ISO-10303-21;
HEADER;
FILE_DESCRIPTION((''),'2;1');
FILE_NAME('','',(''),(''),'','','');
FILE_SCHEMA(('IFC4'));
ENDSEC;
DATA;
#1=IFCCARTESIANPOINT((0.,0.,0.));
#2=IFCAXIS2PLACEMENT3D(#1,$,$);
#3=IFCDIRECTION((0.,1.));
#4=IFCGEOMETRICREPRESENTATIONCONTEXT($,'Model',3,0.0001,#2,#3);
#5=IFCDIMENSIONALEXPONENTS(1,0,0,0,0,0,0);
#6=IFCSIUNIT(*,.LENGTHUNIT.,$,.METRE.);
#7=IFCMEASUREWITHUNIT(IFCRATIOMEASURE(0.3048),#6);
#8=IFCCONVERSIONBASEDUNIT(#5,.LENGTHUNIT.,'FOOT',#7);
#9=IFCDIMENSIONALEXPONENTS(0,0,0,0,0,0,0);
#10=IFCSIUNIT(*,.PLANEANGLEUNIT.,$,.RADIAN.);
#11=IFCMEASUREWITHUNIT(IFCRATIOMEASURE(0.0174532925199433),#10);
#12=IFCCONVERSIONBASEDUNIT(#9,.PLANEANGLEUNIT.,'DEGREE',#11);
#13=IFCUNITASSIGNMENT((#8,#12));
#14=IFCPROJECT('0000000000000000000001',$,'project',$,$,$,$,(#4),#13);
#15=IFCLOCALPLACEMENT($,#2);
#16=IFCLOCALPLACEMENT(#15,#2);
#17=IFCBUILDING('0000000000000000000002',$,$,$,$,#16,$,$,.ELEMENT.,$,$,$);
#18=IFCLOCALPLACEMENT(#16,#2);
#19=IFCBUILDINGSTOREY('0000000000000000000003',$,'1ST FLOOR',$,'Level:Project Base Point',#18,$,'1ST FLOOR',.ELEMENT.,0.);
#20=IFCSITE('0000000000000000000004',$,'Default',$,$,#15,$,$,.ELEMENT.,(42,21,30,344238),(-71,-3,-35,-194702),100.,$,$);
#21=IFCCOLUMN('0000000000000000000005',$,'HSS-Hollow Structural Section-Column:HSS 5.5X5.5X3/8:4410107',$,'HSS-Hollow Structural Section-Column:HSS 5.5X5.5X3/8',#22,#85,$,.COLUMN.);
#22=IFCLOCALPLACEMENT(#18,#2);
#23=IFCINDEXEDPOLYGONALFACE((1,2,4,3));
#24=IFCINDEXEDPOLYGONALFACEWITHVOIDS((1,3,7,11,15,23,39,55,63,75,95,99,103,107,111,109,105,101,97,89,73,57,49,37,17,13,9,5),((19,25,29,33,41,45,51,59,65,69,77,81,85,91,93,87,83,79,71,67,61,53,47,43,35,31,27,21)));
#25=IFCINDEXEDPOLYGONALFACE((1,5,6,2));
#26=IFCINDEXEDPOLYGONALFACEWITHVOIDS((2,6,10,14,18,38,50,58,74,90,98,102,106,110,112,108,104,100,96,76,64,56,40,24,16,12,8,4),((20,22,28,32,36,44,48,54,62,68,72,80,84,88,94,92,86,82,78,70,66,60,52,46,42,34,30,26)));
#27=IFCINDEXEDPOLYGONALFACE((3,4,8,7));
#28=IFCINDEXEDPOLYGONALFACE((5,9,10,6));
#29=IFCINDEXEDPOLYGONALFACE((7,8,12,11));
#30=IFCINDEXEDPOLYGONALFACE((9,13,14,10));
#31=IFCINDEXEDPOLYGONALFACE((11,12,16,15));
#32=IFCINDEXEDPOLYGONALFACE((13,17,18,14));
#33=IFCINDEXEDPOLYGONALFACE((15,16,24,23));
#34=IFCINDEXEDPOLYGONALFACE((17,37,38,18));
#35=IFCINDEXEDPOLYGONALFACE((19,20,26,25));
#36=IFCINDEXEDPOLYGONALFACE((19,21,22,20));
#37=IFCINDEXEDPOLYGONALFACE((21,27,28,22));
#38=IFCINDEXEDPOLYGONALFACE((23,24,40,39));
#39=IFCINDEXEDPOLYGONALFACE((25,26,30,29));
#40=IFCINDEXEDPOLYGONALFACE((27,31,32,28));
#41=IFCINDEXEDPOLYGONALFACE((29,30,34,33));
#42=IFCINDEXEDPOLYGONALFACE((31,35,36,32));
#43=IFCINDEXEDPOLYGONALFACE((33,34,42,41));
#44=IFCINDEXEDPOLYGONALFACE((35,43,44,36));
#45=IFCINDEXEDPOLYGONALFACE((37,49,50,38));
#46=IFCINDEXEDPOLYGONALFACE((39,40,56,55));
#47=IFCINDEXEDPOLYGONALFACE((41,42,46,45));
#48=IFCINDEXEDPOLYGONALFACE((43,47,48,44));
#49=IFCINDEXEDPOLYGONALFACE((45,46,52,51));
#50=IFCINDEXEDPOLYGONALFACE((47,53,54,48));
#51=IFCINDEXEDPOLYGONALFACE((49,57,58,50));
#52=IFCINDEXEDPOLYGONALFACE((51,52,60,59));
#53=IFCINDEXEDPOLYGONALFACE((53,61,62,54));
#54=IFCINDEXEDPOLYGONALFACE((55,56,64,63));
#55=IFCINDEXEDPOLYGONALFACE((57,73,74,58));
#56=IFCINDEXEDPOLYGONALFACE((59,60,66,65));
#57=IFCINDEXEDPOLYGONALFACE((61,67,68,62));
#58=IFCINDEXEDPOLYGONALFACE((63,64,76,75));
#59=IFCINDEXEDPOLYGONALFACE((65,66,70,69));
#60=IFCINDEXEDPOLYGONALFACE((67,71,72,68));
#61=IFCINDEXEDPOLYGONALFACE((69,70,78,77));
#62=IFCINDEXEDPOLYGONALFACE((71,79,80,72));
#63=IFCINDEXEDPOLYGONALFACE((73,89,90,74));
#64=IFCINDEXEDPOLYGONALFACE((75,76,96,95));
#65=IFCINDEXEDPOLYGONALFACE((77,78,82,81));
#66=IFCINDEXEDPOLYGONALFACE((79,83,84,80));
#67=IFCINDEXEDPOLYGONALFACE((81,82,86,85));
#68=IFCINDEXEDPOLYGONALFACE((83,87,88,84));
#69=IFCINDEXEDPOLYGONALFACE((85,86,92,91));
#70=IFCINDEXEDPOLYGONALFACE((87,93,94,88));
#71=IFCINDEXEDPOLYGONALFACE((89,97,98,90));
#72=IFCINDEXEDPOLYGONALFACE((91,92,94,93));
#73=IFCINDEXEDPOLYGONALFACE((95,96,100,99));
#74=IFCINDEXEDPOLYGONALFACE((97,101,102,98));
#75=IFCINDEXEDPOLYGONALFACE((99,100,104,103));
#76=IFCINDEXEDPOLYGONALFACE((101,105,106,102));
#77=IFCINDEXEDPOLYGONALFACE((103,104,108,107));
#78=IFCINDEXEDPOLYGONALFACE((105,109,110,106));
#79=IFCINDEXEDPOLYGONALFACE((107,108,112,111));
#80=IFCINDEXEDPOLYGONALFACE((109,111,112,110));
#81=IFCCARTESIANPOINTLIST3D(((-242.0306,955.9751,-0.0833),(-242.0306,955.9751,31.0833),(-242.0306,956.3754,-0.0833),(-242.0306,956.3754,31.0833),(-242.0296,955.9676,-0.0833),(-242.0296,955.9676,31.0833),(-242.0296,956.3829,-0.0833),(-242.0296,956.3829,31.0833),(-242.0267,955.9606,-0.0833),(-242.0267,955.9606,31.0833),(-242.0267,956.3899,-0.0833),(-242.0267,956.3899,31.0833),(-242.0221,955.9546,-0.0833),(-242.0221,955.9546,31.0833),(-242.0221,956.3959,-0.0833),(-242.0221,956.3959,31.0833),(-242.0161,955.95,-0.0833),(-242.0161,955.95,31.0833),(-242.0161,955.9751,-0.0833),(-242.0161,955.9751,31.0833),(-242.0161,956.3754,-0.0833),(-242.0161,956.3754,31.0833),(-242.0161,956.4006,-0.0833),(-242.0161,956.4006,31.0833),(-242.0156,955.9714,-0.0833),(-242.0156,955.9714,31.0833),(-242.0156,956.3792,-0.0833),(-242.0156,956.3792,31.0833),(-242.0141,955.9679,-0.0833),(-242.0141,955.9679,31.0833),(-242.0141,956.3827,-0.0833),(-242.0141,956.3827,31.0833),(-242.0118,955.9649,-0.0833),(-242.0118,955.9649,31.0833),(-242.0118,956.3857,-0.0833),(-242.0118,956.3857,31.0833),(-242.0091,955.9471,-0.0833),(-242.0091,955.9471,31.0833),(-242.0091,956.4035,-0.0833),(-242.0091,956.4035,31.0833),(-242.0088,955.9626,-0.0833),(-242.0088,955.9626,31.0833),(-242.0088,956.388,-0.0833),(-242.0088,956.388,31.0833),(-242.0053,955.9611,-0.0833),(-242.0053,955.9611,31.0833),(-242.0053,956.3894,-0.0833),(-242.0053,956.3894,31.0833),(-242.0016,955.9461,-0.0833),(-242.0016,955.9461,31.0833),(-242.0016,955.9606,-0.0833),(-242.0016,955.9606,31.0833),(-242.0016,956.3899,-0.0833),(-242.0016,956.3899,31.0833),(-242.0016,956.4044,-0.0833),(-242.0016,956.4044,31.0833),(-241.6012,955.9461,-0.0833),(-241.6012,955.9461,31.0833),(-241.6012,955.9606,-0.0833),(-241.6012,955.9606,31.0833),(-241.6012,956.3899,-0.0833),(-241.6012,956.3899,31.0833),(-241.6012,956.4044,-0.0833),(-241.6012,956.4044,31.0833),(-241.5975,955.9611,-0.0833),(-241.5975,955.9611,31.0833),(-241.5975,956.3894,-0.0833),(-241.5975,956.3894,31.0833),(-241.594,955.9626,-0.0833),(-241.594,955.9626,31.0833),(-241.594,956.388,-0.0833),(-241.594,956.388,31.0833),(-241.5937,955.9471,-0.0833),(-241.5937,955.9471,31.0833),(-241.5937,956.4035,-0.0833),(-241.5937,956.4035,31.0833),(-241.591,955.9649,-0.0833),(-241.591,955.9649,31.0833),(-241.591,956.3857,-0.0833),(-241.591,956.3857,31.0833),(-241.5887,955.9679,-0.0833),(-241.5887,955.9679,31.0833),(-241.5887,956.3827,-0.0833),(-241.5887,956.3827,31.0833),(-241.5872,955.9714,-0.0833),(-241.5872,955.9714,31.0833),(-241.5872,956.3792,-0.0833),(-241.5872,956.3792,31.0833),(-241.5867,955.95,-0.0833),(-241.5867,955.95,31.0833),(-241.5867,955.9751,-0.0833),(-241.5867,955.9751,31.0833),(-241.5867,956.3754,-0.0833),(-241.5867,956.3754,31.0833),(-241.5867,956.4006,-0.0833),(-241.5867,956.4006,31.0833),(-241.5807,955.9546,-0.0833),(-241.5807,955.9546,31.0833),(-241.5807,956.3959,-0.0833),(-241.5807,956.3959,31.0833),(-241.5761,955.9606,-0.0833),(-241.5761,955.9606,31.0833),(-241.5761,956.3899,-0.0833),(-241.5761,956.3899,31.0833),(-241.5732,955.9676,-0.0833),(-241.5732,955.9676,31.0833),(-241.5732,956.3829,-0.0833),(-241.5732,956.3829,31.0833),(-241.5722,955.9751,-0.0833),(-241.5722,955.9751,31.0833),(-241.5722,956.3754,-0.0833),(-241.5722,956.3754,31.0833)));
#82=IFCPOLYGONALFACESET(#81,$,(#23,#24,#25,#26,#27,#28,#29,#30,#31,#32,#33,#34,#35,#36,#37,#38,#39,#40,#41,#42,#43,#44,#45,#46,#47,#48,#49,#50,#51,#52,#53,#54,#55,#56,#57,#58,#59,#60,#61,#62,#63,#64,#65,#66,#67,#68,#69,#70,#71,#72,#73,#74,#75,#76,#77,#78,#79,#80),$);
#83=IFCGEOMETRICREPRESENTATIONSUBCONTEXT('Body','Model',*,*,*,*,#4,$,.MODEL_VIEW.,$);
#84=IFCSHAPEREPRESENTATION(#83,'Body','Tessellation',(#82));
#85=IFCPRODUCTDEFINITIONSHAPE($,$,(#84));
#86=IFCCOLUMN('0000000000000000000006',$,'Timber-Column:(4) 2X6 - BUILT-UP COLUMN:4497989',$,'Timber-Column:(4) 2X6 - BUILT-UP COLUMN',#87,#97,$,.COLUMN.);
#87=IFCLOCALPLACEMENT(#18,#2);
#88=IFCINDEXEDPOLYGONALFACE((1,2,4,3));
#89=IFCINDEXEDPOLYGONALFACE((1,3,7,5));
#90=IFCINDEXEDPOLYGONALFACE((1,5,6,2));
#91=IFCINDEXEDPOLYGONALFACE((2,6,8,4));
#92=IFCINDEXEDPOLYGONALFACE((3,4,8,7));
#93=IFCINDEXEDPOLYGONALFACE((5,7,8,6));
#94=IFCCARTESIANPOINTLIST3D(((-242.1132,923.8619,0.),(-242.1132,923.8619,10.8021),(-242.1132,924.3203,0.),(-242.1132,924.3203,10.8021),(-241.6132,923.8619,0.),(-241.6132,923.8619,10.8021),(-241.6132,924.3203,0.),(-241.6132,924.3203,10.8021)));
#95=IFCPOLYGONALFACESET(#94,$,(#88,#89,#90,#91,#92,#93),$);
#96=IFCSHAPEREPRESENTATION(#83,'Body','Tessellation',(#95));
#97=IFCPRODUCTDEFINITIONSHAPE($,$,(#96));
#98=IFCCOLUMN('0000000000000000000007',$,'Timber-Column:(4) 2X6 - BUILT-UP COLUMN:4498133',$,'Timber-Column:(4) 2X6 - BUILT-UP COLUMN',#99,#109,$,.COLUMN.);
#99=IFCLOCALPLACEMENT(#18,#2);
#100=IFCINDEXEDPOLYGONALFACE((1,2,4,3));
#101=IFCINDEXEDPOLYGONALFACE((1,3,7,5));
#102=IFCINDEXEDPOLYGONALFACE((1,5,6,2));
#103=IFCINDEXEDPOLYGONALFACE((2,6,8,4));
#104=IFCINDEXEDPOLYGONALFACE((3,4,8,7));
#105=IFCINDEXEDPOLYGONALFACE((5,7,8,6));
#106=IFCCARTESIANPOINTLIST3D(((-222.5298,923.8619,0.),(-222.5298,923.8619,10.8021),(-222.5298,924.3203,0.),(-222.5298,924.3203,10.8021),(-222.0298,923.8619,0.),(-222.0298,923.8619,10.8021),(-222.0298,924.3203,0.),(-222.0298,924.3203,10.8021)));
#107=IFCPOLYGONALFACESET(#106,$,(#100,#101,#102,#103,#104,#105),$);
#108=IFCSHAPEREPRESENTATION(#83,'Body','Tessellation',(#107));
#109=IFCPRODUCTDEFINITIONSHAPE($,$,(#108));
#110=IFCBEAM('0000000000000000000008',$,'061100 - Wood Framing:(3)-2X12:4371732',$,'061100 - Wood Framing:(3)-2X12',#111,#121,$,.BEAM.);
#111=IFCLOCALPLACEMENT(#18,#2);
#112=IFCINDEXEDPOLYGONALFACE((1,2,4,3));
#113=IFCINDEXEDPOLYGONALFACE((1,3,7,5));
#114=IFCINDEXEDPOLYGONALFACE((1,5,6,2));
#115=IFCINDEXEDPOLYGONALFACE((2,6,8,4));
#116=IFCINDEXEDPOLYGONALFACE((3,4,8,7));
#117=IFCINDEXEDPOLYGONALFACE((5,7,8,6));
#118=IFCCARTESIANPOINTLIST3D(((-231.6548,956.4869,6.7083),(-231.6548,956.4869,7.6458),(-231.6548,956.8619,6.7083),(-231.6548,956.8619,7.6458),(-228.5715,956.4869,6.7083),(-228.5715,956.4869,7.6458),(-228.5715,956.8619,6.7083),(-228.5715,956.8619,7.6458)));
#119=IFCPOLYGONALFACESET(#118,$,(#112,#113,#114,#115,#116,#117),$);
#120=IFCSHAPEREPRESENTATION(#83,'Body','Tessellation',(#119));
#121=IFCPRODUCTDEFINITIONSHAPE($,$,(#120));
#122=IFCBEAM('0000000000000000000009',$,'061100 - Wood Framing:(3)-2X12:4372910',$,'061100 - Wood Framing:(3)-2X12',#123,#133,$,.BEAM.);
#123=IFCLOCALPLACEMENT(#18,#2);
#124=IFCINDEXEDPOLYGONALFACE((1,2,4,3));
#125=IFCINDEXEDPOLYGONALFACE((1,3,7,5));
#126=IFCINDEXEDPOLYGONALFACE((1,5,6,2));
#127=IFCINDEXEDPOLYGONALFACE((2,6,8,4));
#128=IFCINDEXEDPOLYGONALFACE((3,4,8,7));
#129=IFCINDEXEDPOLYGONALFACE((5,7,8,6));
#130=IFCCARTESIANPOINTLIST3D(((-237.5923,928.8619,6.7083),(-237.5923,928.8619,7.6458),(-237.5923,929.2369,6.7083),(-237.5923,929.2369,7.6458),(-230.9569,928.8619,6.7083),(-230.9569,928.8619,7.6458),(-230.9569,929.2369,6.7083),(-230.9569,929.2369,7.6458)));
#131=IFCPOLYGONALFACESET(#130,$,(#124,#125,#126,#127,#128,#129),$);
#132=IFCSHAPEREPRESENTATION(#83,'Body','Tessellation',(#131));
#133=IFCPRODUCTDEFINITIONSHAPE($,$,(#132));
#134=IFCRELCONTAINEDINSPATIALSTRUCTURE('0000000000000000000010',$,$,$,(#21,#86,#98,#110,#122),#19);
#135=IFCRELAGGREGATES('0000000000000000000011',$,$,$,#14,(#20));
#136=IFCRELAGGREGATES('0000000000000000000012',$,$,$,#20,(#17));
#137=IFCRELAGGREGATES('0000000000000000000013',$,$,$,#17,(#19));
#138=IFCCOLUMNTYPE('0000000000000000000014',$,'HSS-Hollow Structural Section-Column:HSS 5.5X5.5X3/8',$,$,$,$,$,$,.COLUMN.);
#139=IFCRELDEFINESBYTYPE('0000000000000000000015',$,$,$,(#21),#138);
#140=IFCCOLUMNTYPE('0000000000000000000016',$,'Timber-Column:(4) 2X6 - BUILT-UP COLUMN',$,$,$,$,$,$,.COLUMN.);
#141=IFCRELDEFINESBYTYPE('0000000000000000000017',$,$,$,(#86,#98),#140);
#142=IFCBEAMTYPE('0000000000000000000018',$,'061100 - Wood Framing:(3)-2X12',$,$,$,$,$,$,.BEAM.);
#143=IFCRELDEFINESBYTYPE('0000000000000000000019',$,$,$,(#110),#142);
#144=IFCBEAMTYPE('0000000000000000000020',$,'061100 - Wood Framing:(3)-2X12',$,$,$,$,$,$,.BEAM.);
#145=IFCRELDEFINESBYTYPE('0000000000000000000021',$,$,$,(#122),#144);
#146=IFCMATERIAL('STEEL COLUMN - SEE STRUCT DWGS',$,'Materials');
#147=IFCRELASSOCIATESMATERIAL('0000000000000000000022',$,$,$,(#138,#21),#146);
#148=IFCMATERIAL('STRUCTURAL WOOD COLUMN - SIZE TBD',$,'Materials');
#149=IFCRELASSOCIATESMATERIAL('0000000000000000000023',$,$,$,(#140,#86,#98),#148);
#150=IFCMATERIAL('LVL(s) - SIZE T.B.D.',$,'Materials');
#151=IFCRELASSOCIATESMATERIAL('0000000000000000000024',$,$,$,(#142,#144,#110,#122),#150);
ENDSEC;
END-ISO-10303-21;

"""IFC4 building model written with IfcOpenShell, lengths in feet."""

from ifc_helpers import new_model, entity, si_unit, converted_unit, direction, frame, frame_2d, origin, origin_2d_with_axis, place, context, subcontext, project, spatial, polyline, circle_curve, parameter, trimmed, segment, composite_curve, rectangle, outline, extrude, source, transform, mapped, material, material_profile, profile_set, profile_usage, type_object, type_shapes, element, save


model = new_model("IFC4")

# Units and contexts
model_context = context("Model", 3, precision=0.0001, world=origin(), true_north=direction((0.0, 1.0)))
body_context = subcontext(model_context, "Body", "Model", "MODEL_VIEW")
ifc_project = project(units=[converted_unit("LENGTHUNIT", "FOOT", entity("IfcRatioMeasure", 0.3048), si_unit("LENGTHUNIT", "METRE"), dimensions=[1, 0, 0, 0, 0, 0, 0]), converted_unit("PLANEANGLEUNIT", "DEGREE", entity("IfcRatioMeasure", 0.0174532925199433), si_unit("PLANEANGLEUNIT", "RADIAN"), dimensions=[0, 0, 0, 0, 0, 0, 0])], contexts=[model_context])

# Site, building, storey
site_placement = place(None, origin())
site = spatial("IfcSite", under=ifc_project, at=site_placement, Name="Default", CompositionType="ELEMENT", RefLatitude=(42, 21, 30, 344238), RefLongitude=(-71, -3, -35, -194702), RefElevation=100.0)
building_placement = place(site_placement, origin())
building = spatial("IfcBuilding", under=site, at=building_placement, CompositionType="ELEMENT")
storey_placement = place(building_placement, origin())
storey = spatial("IfcBuildingStorey", under=building, at=storey_placement, Name="1ST FLOOR", ObjectType="Level:Project Base Point", LongName="1ST FLOOR", CompositionType="ELEMENT", Elevation=0.0)

# Columns
ifc_material_1 = material(Name="STEEL COLUMN - SEE STRUCT DWGS", Category="Materials")
ifc_material_profile_1 = material_profile(ifc_material_1, outline(composite_curve([segment(trimmed(circle_curve(frame_2d((0.2002, -0.2002), x_axis=(1.0, 0.0)), 0.029), [parameter(270.0)], [parameter(0.0)], True, "PARAMETER"), True, "CONTINUOUS"), segment(polyline([(0.2292, -0.2002), (0.2292, 0.2002)]), True, "CONTINUOUS"), segment(trimmed(circle_curve(frame_2d((0.2002, 0.2002), x_axis=(1.0, 0.0)), 0.029), [parameter(0.0)], [parameter(90.0)], True, "PARAMETER"), True, "CONTINUOUS"), segment(polyline([(0.2002, 0.2292), (-0.2002, 0.2292)]), True, "CONTINUOUS"), segment(trimmed(circle_curve(frame_2d((-0.2002, 0.2002), x_axis=(1.0, 0.0)), 0.029), [parameter(90.0)], [parameter(180.0)], True, "PARAMETER"), True, "CONTINUOUS"), segment(polyline([(-0.2292, 0.2002), (-0.2292, -0.2002)]), True, "CONTINUOUS"), segment(trimmed(circle_curve(frame_2d((-0.2002, -0.2002), x_axis=(1.0, 0.0)), 0.029), [parameter(180.0)], [parameter(270.0)], True, "PARAMETER"), True, "CONTINUOUS"), segment(polyline([(-0.2002, -0.2292), (0.2002, -0.2292)]), True, "CONTINUOUS")], self_intersect=False), holes=[composite_curve([segment(polyline([(0.2002, -0.2147), (-0.2002, -0.2147)]), True, "CONTINUOUS"), segment(trimmed(circle_curve(frame_2d((-0.2002, -0.2002), x_axis=(1.0, 0.0)), 0.0145), [parameter(180.0)], [parameter(270.0)], True, "PARAMETER"), False, "CONTINUOUS"), segment(polyline([(-0.2147, -0.2002), (-0.2147, 0.2002)]), True, "CONTINUOUS"), segment(trimmed(circle_curve(frame_2d((-0.2002, 0.2002), x_axis=(1.0, 0.0)), 0.0145), [parameter(90.0)], [parameter(180.0)], True, "PARAMETER"), False, "CONTINUOUS"), segment(polyline([(-0.2002, 0.2147), (0.2002, 0.2147)]), True, "CONTINUOUS"), segment(trimmed(circle_curve(frame_2d((0.2002, 0.2002), x_axis=(1.0, 0.0)), 0.0145), [parameter(0.0)], [parameter(90.0)], True, "PARAMETER"), False, "CONTINUOUS"), segment(polyline([(0.2147, 0.2002), (0.2147, -0.2002)]), True, "CONTINUOUS"), segment(trimmed(circle_curve(frame_2d((0.2002, -0.2002), x_axis=(1.0, 0.0)), 0.0145), [parameter(270.0)], [parameter(0.0)], True, "PARAMETER"), False, "CONTINUOUS")], self_intersect=False)]), Name="HSS 5.5X5.5X3/8")
ifc_profile_set_1 = profile_set([ifc_material_profile_1], Name="HSS 5.5X5.5X3/8")
ifc_profile_usage_1 = profile_usage(ifc_profile_set_1)
column_type_1 = type_object("IfcColumnType", Name="HSS-Hollow Structural Section-Column:HSS 5.5X5.5X3/8", PredefinedType="COLUMN", material=ifc_profile_set_1)
shared_shape_1 = source(origin(), body_context, "Body", "SweptSolid", [
    extrude(outline(composite_curve([segment(trimmed(circle_curve(frame_2d((0.2002, -0.2002), x_axis=(1.0, 0.0)), 0.029), [parameter(270.0)], [parameter(0.0)], True, "PARAMETER"), True, "CONTINUOUS"), segment(polyline([(0.2292, -0.2002), (0.2292, 0.2002)]), True, "CONTINUOUS"), segment(trimmed(circle_curve(frame_2d((0.2002, 0.2002), x_axis=(1.0, 0.0)), 0.029), [parameter(0.0)], [parameter(90.0)], True, "PARAMETER"), True, "CONTINUOUS"), segment(polyline([(0.2002, 0.2292), (-0.2002, 0.2292)]), True, "CONTINUOUS"), segment(trimmed(circle_curve(frame_2d((-0.2002, 0.2002), x_axis=(1.0, 0.0)), 0.029), [parameter(90.0)], [parameter(180.0)], True, "PARAMETER"), True, "CONTINUOUS"), segment(polyline([(-0.2292, 0.2002), (-0.2292, -0.2002)]), True, "CONTINUOUS"), segment(trimmed(circle_curve(frame_2d((-0.2002, -0.2002), x_axis=(1.0, 0.0)), 0.029), [parameter(180.0)], [parameter(270.0)], True, "PARAMETER"), True, "CONTINUOUS"), segment(polyline([(-0.2002, -0.2292), (0.2002, -0.2292)]), True, "CONTINUOUS")], self_intersect=False), holes=[composite_curve([segment(polyline([(0.2002, -0.2147), (-0.2002, -0.2147)]), True, "CONTINUOUS"), segment(trimmed(circle_curve(frame_2d((-0.2002, -0.2002), x_axis=(1.0, 0.0)), 0.0145), [parameter(180.0)], [parameter(270.0)], True, "PARAMETER"), False, "CONTINUOUS"), segment(polyline([(-0.2147, -0.2002), (-0.2147, 0.2002)]), True, "CONTINUOUS"), segment(trimmed(circle_curve(frame_2d((-0.2002, 0.2002), x_axis=(1.0, 0.0)), 0.0145), [parameter(90.0)], [parameter(180.0)], True, "PARAMETER"), False, "CONTINUOUS"), segment(polyline([(-0.2002, 0.2147), (0.2002, 0.2147)]), True, "CONTINUOUS"), segment(trimmed(circle_curve(frame_2d((0.2002, 0.2002), x_axis=(1.0, 0.0)), 0.0145), [parameter(0.0)], [parameter(90.0)], True, "PARAMETER"), False, "CONTINUOUS"), segment(polyline([(0.2147, 0.2002), (0.2147, -0.2002)]), True, "CONTINUOUS"), segment(trimmed(circle_curve(frame_2d((0.2002, -0.2002), x_axis=(1.0, 0.0)), 0.0145), [parameter(270.0)], [parameter(0.0)], True, "PARAMETER"), False, "CONTINUOUS")], self_intersect=False)]), frame((0.0, 0.0, -0.0833)), (0.0, 0.0, 1.0), 31.1667),
])
type_shapes(column_type_1, [shared_shape_1])
column_1_placement = place(storey_placement, frame((-241.8014, 956.1753, 0.0), z_axis=(0.0, 0.0, 1.0), x_axis=(-1.0, 0.0, 0.0)))
element("IfcColumn", 1, at=column_1_placement, inside=storey, type_object=column_type_1, material=ifc_profile_usage_1, Name="HSS-Hollow Structural Section-Column:HSS 5.5X5.5X3/8:4410107", ObjectType="HSS-Hollow Structural Section-Column:HSS 5.5X5.5X3/8", PredefinedType="COLUMN", context=body_context, shape_type="MappedRepresentation", body=[
    mapped(shared_shape_1, transform((0.0, 0.0, 0.0), scale=1.0)),
])
ifc_material_2 = material(Name="STRUCTURAL WOOD COLUMN - SIZE TBD", Category="Materials")
ifc_material_profile_2 = material_profile(ifc_material_2, rectangle(XDim=0.4583, YDim=0.5, at=frame_2d((0.0, 0.0), x_axis=(1.0, 0.0))), Name="(4) 2X6 - BUILT-UP COLUMN")
ifc_profile_set_2 = profile_set([ifc_material_profile_2], Name="(4) 2X6 - BUILT-UP COLUMN")
ifc_profile_usage_2 = profile_usage(ifc_profile_set_2)
column_type_2 = type_object("IfcColumnType", Name="Timber-Column:(4) 2X6 - BUILT-UP COLUMN", PredefinedType="COLUMN", material=ifc_profile_set_2)
shared_shape_2 = source(origin(), body_context, "Body", "SweptSolid", [
    extrude(rectangle(XDim=0.4583, YDim=0.5, at=frame_2d((0.0, 0.0), x_axis=(1.0, 0.0))), frame((0.0, 0.0, 0.0), z_axis=(0.0, 0.0, 1.0), x_axis=(0.0, -1.0, 0.0)), (0.0, 0.0, 1.0), 10.8021),
])
type_shapes(column_type_2, [shared_shape_2])
column_2_placement = place(storey_placement, frame((-241.8632, 924.0911, 0.0)))
element("IfcColumn", 2, at=column_2_placement, inside=storey, type_object=column_type_2, material=ifc_profile_usage_2, Name="Timber-Column:(4) 2X6 - BUILT-UP COLUMN:4497989", ObjectType="Timber-Column:(4) 2X6 - BUILT-UP COLUMN", PredefinedType="COLUMN", context=body_context, shape_type="MappedRepresentation", body=[
    mapped(shared_shape_2, transform((0.0, 0.0, 0.0), scale=1.0)),
])
ifc_profile_usage_3 = profile_usage(ifc_profile_set_2)
column_3_placement = place(storey_placement, frame((-222.2798, 924.0911, 0.0)))
element("IfcColumn", 3, at=column_3_placement, inside=storey, type_object=column_type_2, material=ifc_profile_usage_3, Name="Timber-Column:(4) 2X6 - BUILT-UP COLUMN:4498133", ObjectType="Timber-Column:(4) 2X6 - BUILT-UP COLUMN", PredefinedType="COLUMN", context=body_context, shape_type="MappedRepresentation", body=[
    mapped(shared_shape_2, transform((0.0, 0.0, 0.0), scale=1.0)),
])

# Beams
ifc_material_3 = material(Name="LVL(s) - SIZE T.B.D.", Category="Materials")
ifc_material_profile_3 = material_profile(ifc_material_3, rectangle(XDim=0.9375, YDim=0.375, at=frame_2d((0.0, 0.0), x_axis=(1.0, 0.0))), Name="(3)-2X12")
ifc_profile_set_3 = profile_set([ifc_material_profile_3], Name="(3)-2X12")
ifc_profile_usage_4 = profile_usage(ifc_profile_set_3, cardinal=8)
beam_type_1 = type_object("IfcBeamType", Name="061100 - Wood Framing:(3)-2X12", PredefinedType="BEAM", material=ifc_profile_set_3)
shared_shape_3 = source(origin(), body_context, "Body", "SweptSolid", [
    extrude(rectangle(XDim=0.9375, YDim=0.375, at=origin_2d_with_axis()), frame((-1.5412, 0.0, 0.0), z_axis=(1.0, 0.0, 0.0), x_axis=(0.0, 0.0, -1.0)), (0.0, 0.0, 1.0), 3.0833),
])
type_shapes(beam_type_1, [shared_shape_3])
beam_1_placement = place(storey_placement, frame((-230.1136, 956.6744, 7.1771)))
element("IfcBeam", 4, at=beam_1_placement, inside=storey, type_object=beam_type_1, material=ifc_profile_usage_4, Name="061100 - Wood Framing:(3)-2X12:4371732", ObjectType="061100 - Wood Framing:(3)-2X12", PredefinedType="BEAM", context=body_context, shape_type="MappedRepresentation", body=[
    mapped(shared_shape_3, transform((0.0, 0.0, 0.0), scale=1.0)),
])
ifc_profile_usage_5 = profile_usage(ifc_profile_set_3, cardinal=8)
beam_type_2 = type_object("IfcBeamType", Name="061100 - Wood Framing:(3)-2X12", PredefinedType="BEAM", material=ifc_profile_set_3)
shared_shape_4 = source(origin(), body_context, "Body", "SweptSolid", [
    extrude(rectangle(XDim=0.9375, YDim=0.375, at=frame_2d((0.0, 0.0), x_axis=(1.0, 0.0))), frame((-3.3184, 0.0, 0.0), z_axis=(1.0, 0.0, 0.0), x_axis=(0.0, 0.0, -1.0)), (0.0, 0.0, 1.0), 6.6354),
])
type_shapes(beam_type_2, [shared_shape_4])
beam_2_placement = place(storey_placement, frame((-234.274, 929.0494, 7.1771)))
element("IfcBeam", 5, at=beam_2_placement, inside=storey, type_object=beam_type_2, material=ifc_profile_usage_5, Name="061100 - Wood Framing:(3)-2X12:4372910", ObjectType="061100 - Wood Framing:(3)-2X12", PredefinedType="BEAM", context=body_context, shape_type="MappedRepresentation", body=[
    mapped(shared_shape_4, transform((0.0, 0.0, 0.0), scale=1.0)),
])

save(model, "model.ifc")
